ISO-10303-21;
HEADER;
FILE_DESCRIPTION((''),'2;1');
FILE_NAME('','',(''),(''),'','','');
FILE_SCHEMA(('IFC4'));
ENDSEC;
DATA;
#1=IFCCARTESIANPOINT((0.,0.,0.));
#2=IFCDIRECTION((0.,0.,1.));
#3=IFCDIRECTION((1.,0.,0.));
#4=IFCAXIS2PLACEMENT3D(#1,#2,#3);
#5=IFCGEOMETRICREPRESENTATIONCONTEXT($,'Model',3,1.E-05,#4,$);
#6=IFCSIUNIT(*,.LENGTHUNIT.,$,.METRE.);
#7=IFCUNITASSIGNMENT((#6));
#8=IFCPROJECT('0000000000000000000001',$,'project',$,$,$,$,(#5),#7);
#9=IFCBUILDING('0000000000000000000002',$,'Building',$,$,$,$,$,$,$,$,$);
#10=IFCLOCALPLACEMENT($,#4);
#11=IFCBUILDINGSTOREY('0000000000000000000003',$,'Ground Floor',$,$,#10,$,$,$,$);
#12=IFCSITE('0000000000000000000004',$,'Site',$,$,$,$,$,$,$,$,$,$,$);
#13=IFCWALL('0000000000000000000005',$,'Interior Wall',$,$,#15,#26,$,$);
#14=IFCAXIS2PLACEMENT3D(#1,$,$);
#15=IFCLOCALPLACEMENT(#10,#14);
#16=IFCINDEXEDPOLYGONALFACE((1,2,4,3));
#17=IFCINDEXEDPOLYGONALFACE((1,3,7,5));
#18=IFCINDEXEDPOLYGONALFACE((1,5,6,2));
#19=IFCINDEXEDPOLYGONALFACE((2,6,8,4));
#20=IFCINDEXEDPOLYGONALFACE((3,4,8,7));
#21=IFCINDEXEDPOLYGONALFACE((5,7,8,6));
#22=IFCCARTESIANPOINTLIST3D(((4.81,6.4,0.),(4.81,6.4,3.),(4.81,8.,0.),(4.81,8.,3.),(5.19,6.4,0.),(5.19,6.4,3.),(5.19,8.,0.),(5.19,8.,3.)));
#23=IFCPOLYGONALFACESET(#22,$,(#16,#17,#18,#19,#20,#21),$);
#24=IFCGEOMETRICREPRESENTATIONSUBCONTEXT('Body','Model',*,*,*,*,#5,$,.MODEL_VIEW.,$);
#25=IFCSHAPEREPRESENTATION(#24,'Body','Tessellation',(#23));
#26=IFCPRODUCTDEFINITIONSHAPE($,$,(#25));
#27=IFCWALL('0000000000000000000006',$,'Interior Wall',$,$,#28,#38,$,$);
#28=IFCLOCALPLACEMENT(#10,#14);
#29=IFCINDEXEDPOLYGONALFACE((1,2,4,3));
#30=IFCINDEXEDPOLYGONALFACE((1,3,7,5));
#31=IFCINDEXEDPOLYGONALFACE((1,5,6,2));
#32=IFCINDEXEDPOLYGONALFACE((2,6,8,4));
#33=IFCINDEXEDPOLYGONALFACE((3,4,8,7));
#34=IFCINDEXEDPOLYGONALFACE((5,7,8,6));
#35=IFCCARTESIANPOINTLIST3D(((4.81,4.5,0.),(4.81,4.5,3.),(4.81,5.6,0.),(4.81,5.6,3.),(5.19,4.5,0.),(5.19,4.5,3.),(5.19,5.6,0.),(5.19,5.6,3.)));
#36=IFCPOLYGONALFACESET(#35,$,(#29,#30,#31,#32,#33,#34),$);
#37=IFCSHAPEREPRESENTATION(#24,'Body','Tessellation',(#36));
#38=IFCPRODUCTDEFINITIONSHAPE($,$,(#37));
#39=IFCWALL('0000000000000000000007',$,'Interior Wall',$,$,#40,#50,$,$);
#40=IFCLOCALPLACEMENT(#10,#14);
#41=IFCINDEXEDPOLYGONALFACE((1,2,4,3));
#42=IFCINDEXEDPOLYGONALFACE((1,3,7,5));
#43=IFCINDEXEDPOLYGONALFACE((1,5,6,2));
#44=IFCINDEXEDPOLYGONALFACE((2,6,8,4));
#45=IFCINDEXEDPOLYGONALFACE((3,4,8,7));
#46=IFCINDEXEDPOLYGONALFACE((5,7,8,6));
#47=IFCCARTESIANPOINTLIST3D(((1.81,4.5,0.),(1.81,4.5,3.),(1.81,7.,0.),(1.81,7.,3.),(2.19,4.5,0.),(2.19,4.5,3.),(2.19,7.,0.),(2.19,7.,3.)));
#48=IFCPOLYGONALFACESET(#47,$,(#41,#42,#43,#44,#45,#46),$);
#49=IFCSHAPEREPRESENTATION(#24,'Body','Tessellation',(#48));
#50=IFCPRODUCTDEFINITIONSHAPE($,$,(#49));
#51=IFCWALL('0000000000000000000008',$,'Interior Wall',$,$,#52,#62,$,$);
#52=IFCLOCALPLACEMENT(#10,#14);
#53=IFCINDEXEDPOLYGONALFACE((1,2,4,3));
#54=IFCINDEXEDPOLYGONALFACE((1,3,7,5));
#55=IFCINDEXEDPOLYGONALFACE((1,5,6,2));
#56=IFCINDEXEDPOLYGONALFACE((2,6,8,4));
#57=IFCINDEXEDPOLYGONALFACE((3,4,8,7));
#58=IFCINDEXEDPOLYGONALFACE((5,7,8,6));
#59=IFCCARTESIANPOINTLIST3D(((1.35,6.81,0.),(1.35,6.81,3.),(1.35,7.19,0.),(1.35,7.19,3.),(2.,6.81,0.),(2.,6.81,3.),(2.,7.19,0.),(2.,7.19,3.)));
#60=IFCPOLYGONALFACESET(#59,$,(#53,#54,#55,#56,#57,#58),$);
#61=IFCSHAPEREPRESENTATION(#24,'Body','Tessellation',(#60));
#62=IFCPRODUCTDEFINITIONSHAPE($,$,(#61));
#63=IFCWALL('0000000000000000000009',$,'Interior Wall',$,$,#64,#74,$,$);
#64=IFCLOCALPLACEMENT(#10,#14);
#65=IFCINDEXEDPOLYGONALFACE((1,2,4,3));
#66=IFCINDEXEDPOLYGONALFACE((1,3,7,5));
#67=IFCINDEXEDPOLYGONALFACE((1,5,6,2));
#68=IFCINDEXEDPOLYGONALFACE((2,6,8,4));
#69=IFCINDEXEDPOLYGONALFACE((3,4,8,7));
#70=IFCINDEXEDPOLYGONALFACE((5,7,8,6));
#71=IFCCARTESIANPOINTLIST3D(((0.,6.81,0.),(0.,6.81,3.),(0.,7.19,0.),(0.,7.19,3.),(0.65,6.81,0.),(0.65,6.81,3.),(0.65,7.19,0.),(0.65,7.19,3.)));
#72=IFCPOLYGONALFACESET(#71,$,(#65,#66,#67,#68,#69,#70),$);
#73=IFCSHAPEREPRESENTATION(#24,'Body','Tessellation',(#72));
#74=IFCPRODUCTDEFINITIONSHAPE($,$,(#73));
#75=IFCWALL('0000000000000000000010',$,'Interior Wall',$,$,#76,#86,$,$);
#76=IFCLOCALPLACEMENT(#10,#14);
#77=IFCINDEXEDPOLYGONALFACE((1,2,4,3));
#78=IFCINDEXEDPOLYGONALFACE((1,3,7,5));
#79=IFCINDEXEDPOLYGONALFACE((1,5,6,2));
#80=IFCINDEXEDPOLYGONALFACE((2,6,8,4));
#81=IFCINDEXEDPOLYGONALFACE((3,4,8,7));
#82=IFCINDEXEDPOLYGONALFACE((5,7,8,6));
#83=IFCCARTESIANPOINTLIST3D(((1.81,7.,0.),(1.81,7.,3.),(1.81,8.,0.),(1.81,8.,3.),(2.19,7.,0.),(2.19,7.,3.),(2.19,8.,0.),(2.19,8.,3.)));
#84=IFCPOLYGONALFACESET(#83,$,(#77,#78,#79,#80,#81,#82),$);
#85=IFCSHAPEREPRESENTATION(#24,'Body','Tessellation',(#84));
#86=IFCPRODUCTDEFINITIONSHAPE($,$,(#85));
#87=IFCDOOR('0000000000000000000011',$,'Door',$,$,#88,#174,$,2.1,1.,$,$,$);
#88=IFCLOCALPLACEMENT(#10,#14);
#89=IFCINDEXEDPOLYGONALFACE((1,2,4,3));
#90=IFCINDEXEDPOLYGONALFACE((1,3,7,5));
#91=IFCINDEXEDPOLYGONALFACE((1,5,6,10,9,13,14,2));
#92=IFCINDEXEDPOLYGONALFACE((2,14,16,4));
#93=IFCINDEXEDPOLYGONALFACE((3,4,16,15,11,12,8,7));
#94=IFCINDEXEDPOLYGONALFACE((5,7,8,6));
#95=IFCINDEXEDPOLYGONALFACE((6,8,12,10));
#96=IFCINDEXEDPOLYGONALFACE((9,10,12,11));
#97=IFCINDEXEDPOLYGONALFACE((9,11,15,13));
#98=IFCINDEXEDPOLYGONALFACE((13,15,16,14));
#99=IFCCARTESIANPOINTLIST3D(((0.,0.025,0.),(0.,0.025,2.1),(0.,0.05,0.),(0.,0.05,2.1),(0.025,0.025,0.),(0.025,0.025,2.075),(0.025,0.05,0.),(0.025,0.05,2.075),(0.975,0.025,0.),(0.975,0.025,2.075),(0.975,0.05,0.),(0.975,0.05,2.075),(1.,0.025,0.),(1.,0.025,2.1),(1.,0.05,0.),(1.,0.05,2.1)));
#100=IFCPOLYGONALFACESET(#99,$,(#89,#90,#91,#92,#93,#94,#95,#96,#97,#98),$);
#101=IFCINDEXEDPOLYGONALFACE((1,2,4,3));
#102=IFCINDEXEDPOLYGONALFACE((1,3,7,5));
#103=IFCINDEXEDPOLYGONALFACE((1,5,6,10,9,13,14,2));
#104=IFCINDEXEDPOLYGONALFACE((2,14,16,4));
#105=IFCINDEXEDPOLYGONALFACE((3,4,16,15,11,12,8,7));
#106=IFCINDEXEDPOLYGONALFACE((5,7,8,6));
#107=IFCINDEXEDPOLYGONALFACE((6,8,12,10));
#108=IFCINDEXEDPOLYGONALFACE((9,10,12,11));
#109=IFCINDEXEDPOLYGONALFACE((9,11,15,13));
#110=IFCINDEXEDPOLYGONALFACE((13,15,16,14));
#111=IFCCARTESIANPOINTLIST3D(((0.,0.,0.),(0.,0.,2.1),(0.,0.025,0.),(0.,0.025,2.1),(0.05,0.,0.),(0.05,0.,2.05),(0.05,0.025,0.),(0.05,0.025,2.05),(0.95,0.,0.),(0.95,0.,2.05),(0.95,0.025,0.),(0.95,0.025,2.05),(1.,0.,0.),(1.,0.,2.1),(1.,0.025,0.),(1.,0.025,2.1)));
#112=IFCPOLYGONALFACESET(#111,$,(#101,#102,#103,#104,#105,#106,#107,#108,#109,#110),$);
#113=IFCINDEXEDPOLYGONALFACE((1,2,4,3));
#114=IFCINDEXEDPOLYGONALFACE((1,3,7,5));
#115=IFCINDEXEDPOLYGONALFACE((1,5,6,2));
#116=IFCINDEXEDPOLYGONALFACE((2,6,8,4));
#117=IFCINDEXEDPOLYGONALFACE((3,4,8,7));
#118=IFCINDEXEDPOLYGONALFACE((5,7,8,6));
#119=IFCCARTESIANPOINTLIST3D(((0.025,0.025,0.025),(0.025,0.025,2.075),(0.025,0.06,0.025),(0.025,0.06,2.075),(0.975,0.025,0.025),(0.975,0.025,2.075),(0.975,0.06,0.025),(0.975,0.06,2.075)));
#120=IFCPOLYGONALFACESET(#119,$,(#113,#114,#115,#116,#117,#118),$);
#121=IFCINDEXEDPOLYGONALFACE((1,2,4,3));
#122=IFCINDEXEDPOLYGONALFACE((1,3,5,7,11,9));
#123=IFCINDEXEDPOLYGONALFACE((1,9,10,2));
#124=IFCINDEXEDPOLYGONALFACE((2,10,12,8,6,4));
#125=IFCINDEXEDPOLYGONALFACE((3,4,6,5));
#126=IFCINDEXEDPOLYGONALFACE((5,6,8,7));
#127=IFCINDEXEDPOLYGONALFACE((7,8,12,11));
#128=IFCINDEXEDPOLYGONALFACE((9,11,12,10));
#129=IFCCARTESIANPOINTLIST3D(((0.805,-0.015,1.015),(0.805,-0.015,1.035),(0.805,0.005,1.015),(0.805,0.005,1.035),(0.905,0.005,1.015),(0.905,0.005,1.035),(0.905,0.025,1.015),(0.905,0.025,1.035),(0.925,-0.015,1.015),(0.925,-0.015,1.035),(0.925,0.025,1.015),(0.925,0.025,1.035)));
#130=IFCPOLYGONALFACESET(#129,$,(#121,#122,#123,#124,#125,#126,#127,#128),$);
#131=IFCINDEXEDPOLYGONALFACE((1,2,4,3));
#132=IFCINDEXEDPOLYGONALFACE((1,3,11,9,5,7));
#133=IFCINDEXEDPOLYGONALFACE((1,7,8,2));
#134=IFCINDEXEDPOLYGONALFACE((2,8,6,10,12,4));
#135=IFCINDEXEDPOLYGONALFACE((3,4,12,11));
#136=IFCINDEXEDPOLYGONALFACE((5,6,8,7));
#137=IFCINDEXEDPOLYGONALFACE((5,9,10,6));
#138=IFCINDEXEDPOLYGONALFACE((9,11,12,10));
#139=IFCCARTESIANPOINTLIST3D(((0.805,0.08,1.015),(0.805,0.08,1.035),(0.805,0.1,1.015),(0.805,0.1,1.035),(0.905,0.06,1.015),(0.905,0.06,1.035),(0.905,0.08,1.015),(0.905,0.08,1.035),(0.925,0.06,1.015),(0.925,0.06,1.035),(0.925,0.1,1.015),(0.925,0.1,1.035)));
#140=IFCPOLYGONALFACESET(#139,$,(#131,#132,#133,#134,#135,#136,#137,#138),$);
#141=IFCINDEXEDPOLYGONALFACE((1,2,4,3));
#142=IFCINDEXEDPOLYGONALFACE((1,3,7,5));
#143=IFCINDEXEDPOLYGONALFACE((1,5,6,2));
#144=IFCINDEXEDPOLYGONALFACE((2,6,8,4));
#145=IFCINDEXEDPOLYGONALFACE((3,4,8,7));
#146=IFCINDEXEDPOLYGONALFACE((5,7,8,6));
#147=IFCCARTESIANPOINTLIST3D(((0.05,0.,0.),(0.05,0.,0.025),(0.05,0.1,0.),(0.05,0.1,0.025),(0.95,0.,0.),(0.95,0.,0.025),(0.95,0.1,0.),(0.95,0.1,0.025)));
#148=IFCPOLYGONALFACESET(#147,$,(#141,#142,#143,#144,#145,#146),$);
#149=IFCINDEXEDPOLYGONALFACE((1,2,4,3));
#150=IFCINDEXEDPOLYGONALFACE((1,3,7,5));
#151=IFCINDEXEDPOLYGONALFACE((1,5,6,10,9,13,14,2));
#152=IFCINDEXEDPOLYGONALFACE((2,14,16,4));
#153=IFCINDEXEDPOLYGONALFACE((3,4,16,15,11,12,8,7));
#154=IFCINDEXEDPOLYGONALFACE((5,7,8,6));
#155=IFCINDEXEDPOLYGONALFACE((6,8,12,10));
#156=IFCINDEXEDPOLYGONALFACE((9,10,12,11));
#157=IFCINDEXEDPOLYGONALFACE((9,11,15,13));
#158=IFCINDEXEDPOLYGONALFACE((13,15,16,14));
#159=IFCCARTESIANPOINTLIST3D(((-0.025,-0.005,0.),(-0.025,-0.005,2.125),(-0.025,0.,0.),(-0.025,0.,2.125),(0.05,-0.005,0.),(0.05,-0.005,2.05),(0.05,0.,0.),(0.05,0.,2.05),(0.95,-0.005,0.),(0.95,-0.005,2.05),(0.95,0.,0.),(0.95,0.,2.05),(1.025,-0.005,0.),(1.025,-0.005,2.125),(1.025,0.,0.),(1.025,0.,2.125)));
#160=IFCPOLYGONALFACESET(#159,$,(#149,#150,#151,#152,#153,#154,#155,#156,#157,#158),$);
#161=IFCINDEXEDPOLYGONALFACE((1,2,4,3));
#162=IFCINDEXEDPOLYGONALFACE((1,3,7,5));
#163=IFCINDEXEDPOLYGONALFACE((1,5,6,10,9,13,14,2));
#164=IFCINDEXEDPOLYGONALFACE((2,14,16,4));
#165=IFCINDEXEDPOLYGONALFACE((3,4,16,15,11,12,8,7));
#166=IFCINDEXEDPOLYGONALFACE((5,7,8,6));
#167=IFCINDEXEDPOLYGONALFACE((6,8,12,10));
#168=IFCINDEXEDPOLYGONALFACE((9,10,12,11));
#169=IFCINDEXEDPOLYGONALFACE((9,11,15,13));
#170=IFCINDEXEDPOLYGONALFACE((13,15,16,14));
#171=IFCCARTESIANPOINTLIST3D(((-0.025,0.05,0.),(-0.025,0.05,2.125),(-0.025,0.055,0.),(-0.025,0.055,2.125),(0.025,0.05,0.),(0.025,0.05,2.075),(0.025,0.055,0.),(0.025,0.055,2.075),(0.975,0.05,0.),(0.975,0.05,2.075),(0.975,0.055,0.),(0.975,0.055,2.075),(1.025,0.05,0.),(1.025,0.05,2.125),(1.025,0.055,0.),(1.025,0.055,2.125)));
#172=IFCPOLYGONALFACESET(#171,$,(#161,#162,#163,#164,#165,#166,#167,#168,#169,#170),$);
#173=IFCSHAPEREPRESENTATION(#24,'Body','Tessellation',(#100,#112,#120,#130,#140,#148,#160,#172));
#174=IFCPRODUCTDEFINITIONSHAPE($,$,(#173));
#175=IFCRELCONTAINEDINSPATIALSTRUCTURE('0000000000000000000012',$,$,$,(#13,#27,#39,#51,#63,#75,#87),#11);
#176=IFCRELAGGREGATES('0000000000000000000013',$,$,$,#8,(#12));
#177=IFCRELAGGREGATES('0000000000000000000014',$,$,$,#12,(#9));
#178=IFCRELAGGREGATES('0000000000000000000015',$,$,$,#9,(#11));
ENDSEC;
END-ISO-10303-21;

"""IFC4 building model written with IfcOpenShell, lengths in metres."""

from ifc_helpers import new_model, si_unit, frame, origin_with_axes, place, context, subcontext, project, spatial, line, indexed_curve, outline, extrude, element, save


model = new_model("IFC4")

# Units and contexts
model_context = context("Model", 3, precision=1e-05, world=origin_with_axes())
body_context = subcontext(model_context, "Body", "Model", "MODEL_VIEW")
ifc_project = project(units=[si_unit("LENGTHUNIT", "METRE")], contexts=[model_context])

# Site, building, storey
site = spatial("IfcSite", under=ifc_project, Name="Site")
building = spatial("IfcBuilding", under=site, Name="Building")
storey_placement = place(None, origin_with_axes())
storey = spatial("IfcBuildingStorey", under=building, at=storey_placement, Name="Ground Floor")

# Walls
wall_1_placement = place(storey_placement, frame((5.0, 8.0, 0.0), z_axis=(0.0, 0.0, 1.0), x_axis=(0.0, -1.0, 0.0)))
element("IfcWall", 1, at=wall_1_placement, inside=storey, Name="Interior Wall", context=body_context, shape_type="SweptSolid", body=[
    extrude(outline(indexed_curve([(0.0, 0.0), (0.0, 0.38), (1.6, 0.38), (1.6, 0.0), (0.0, 0.0)], self_intersect=False)), frame((0.0, -0.19, 0.0), z_axis=(0.0, 0.0, 1.0), x_axis=(1.0, 0.0, 0.0)), (0.0, 0.0, 1.0), 3.0),
])
wall_2_placement = place(storey_placement, frame((5.0, 5.6, 0.0), z_axis=(0.0, 0.0, 1.0), x_axis=(0.0, -1.0, 0.0)))
element("IfcWall", 2, at=wall_2_placement, inside=storey, Name="Interior Wall", context=body_context, shape_type="SweptSolid", body=[
    extrude(outline(indexed_curve([(0.0, 0.0), (0.0, 0.38), (1.1, 0.38), (1.1, 0.0), (0.0, 0.0)], self_intersect=False)), frame((0.0, -0.19, 0.0), z_axis=(0.0, 0.0, 1.0), x_axis=(1.0, 0.0, 0.0)), (0.0, 0.0, 1.0), 3.0),
])
wall_3_placement = place(storey_placement, frame((2.0, 4.5, 0.0), z_axis=(0.0, 0.0, 1.0), x_axis=(0.0, 1.0, 0.0)))
element("IfcWall", 3, at=wall_3_placement, inside=storey, Name="Interior Wall", context=body_context, shape_type="SweptSolid", body=[
    extrude(outline(indexed_curve([(0.0, 0.0), (0.0, 0.38), (2.5, 0.38), (2.5, 0.0), (0.0, 0.0)], self_intersect=False)), frame((0.0, -0.19, 0.0), z_axis=(0.0, 0.0, 1.0), x_axis=(1.0, 0.0, 0.0)), (0.0, 0.0, 1.0), 3.0),
])
for number, where, z_axis, x_axis, name in (
    (4, (2.0, 7.0, 0.0), (0.0, 0.0, 1.0), (-1.0, 0.0, 0.0), "Interior Wall"),
    (5, (0.65, 7.0, 0.0), (0.0, 0.0, 1.0), (-1.0, 0.0, 0.0), "Interior Wall"),
):
    element("IfcWall", number, at=place(storey_placement, frame(where, z_axis=z_axis, x_axis=x_axis)), inside=storey, Name=name, context=body_context, shape_type="SweptSolid", body=[
        extrude(outline(indexed_curve([(0.0, 0.0), (0.0, 0.38), (0.65, 0.38), (0.65, 0.0), (0.0, 0.0)], self_intersect=False)), frame((0.0, -0.19, 0.0), z_axis=(0.0, 0.0, 1.0), x_axis=(1.0, 0.0, 0.0)), (0.0, 0.0, 1.0), 3.0),
    ])
wall_4_placement = place(storey_placement, frame((2.0, 8.0, 0.0), z_axis=(0.0, 0.0, 1.0), x_axis=(0.0, -1.0, 0.0)))
element("IfcWall", 6, at=wall_4_placement, inside=storey, Name="Interior Wall", context=body_context, shape_type="SweptSolid", body=[
    extrude(outline(indexed_curve([(0.0, 0.0), (0.0, 0.38), (1.0, 0.38), (1.0, 0.0), (0.0, 0.0)], self_intersect=False)), frame((0.0, -0.19, 0.0), z_axis=(0.0, 0.0, 1.0), x_axis=(1.0, 0.0, 0.0)), (0.0, 0.0, 1.0), 3.0),
])

# Door
door_1_placement = place(storey_placement, origin_with_axes())
element("IfcDoor", 7, at=door_1_placement, inside=storey, Name="Door", OverallHeight=2.1, OverallWidth=1.0, context=body_context, shape_type="SweptSolid", body=[
    extrude(outline(indexed_curve([(0.0, 0.0), (0.0, 2.1), (1.0, 2.1), (1.0, 0.0), (0.975, 0.0), (0.975, 2.075), (0.025, 2.075), (0.025, 0.0)], segments=[line(1, 2, 3, 4, 5, 6, 7, 8, 1)])), frame((0.0, 0.025, 0.0), z_axis=(0.0, -1.0, 0.0), x_axis=(1.0, 0.0, 0.0)), (0.0, 0.0, -1.0), 0.025),
    extrude(outline(indexed_curve([(0.0, 0.0), (0.0, 2.1), (1.0, 2.1), (1.0, 0.0), (0.95, 0.0), (0.95, 2.05), (0.05, 2.05), (0.05, 0.0)], segments=[line(1, 2, 3, 4, 5, 6, 7, 8, 1)])), frame((0.0, 0.0, 0.0), z_axis=(0.0, -1.0, 0.0), x_axis=(1.0, 0.0, 0.0)), (0.0, 0.0, -1.0), 0.025),
    extrude(outline(indexed_curve([(0.0, 0.0), (0.95, 0.0), (0.95, 0.035), (0.0, 0.035)], segments=[line(1, 2, 3, 4, 1)])), frame((0.025, 0.025, 0.025), z_axis=(0.0, 0.0, 1.0), x_axis=(1.0, 0.0, 0.0)), (0.0, 0.0, 1.0), 2.05),
    extrude(outline(indexed_curve([(0.0, 0.0), (0.0, -0.04), (-0.12, -0.04), (-0.12, -0.02), (-0.02, -0.02), (-0.02, 0.0)], segments=[line(1, 2, 3, 4, 5, 6, 1)])), frame((0.925, 0.025, 1.015), z_axis=(0.0, 0.0, 1.0), x_axis=(1.0, 0.0, 0.0)), (0.0, 0.0, 1.0), 0.02),
    extrude(outline(indexed_curve([(0.0, 0.0), (0.0, 0.04), (-0.12, 0.04), (-0.12, 0.02), (-0.02, 0.02), (-0.02, 0.0)], segments=[line(1, 2, 3, 4, 5, 6, 1)])), frame((0.925, 0.06, 1.015), z_axis=(0.0, 0.0, 1.0), x_axis=(1.0, 0.0, 0.0)), (0.0, 0.0, 1.0), 0.02),
    extrude(outline(indexed_curve([(0.0, 0.0), (0.9, 0.0), (0.9, 0.1), (0.0, 0.1)], segments=[line(1, 2, 3, 4, 1)])), frame((0.05, 0.0, 0.0), z_axis=(0.0, 0.0, 1.0), x_axis=(1.0, 0.0, 0.0)), (0.0, 0.0, 1.0), 0.025),
    extrude(outline(indexed_curve([(0.0, 0.0), (0.0, 2.125), (1.05, 2.125), (1.05, 0.0), (0.975, 0.0), (0.975, 2.05), (0.075, 2.05), (0.075, 0.0)], segments=[line(1, 2, 3, 4, 5, 6, 7, 8, 1)])), frame((-0.025, -0.005, 0.0), z_axis=(0.0, -1.0, 0.0), x_axis=(1.0, 0.0, 0.0)), (0.0, 0.0, -1.0), 0.005),
    extrude(outline(indexed_curve([(0.0, 0.0), (0.0, 2.125), (1.05, 2.125), (1.05, 0.0), (1.0, 0.0), (1.0, 2.075), (0.05, 2.075), (0.05, 0.0)], segments=[line(1, 2, 3, 4, 5, 6, 7, 8, 1)])), frame((-0.025, 0.05, 0.0), z_axis=(0.0, -1.0, 0.0), x_axis=(1.0, 0.0, 0.0)), (0.0, 0.0, -1.0), 0.005),
])

save(model, "model.ifc")
